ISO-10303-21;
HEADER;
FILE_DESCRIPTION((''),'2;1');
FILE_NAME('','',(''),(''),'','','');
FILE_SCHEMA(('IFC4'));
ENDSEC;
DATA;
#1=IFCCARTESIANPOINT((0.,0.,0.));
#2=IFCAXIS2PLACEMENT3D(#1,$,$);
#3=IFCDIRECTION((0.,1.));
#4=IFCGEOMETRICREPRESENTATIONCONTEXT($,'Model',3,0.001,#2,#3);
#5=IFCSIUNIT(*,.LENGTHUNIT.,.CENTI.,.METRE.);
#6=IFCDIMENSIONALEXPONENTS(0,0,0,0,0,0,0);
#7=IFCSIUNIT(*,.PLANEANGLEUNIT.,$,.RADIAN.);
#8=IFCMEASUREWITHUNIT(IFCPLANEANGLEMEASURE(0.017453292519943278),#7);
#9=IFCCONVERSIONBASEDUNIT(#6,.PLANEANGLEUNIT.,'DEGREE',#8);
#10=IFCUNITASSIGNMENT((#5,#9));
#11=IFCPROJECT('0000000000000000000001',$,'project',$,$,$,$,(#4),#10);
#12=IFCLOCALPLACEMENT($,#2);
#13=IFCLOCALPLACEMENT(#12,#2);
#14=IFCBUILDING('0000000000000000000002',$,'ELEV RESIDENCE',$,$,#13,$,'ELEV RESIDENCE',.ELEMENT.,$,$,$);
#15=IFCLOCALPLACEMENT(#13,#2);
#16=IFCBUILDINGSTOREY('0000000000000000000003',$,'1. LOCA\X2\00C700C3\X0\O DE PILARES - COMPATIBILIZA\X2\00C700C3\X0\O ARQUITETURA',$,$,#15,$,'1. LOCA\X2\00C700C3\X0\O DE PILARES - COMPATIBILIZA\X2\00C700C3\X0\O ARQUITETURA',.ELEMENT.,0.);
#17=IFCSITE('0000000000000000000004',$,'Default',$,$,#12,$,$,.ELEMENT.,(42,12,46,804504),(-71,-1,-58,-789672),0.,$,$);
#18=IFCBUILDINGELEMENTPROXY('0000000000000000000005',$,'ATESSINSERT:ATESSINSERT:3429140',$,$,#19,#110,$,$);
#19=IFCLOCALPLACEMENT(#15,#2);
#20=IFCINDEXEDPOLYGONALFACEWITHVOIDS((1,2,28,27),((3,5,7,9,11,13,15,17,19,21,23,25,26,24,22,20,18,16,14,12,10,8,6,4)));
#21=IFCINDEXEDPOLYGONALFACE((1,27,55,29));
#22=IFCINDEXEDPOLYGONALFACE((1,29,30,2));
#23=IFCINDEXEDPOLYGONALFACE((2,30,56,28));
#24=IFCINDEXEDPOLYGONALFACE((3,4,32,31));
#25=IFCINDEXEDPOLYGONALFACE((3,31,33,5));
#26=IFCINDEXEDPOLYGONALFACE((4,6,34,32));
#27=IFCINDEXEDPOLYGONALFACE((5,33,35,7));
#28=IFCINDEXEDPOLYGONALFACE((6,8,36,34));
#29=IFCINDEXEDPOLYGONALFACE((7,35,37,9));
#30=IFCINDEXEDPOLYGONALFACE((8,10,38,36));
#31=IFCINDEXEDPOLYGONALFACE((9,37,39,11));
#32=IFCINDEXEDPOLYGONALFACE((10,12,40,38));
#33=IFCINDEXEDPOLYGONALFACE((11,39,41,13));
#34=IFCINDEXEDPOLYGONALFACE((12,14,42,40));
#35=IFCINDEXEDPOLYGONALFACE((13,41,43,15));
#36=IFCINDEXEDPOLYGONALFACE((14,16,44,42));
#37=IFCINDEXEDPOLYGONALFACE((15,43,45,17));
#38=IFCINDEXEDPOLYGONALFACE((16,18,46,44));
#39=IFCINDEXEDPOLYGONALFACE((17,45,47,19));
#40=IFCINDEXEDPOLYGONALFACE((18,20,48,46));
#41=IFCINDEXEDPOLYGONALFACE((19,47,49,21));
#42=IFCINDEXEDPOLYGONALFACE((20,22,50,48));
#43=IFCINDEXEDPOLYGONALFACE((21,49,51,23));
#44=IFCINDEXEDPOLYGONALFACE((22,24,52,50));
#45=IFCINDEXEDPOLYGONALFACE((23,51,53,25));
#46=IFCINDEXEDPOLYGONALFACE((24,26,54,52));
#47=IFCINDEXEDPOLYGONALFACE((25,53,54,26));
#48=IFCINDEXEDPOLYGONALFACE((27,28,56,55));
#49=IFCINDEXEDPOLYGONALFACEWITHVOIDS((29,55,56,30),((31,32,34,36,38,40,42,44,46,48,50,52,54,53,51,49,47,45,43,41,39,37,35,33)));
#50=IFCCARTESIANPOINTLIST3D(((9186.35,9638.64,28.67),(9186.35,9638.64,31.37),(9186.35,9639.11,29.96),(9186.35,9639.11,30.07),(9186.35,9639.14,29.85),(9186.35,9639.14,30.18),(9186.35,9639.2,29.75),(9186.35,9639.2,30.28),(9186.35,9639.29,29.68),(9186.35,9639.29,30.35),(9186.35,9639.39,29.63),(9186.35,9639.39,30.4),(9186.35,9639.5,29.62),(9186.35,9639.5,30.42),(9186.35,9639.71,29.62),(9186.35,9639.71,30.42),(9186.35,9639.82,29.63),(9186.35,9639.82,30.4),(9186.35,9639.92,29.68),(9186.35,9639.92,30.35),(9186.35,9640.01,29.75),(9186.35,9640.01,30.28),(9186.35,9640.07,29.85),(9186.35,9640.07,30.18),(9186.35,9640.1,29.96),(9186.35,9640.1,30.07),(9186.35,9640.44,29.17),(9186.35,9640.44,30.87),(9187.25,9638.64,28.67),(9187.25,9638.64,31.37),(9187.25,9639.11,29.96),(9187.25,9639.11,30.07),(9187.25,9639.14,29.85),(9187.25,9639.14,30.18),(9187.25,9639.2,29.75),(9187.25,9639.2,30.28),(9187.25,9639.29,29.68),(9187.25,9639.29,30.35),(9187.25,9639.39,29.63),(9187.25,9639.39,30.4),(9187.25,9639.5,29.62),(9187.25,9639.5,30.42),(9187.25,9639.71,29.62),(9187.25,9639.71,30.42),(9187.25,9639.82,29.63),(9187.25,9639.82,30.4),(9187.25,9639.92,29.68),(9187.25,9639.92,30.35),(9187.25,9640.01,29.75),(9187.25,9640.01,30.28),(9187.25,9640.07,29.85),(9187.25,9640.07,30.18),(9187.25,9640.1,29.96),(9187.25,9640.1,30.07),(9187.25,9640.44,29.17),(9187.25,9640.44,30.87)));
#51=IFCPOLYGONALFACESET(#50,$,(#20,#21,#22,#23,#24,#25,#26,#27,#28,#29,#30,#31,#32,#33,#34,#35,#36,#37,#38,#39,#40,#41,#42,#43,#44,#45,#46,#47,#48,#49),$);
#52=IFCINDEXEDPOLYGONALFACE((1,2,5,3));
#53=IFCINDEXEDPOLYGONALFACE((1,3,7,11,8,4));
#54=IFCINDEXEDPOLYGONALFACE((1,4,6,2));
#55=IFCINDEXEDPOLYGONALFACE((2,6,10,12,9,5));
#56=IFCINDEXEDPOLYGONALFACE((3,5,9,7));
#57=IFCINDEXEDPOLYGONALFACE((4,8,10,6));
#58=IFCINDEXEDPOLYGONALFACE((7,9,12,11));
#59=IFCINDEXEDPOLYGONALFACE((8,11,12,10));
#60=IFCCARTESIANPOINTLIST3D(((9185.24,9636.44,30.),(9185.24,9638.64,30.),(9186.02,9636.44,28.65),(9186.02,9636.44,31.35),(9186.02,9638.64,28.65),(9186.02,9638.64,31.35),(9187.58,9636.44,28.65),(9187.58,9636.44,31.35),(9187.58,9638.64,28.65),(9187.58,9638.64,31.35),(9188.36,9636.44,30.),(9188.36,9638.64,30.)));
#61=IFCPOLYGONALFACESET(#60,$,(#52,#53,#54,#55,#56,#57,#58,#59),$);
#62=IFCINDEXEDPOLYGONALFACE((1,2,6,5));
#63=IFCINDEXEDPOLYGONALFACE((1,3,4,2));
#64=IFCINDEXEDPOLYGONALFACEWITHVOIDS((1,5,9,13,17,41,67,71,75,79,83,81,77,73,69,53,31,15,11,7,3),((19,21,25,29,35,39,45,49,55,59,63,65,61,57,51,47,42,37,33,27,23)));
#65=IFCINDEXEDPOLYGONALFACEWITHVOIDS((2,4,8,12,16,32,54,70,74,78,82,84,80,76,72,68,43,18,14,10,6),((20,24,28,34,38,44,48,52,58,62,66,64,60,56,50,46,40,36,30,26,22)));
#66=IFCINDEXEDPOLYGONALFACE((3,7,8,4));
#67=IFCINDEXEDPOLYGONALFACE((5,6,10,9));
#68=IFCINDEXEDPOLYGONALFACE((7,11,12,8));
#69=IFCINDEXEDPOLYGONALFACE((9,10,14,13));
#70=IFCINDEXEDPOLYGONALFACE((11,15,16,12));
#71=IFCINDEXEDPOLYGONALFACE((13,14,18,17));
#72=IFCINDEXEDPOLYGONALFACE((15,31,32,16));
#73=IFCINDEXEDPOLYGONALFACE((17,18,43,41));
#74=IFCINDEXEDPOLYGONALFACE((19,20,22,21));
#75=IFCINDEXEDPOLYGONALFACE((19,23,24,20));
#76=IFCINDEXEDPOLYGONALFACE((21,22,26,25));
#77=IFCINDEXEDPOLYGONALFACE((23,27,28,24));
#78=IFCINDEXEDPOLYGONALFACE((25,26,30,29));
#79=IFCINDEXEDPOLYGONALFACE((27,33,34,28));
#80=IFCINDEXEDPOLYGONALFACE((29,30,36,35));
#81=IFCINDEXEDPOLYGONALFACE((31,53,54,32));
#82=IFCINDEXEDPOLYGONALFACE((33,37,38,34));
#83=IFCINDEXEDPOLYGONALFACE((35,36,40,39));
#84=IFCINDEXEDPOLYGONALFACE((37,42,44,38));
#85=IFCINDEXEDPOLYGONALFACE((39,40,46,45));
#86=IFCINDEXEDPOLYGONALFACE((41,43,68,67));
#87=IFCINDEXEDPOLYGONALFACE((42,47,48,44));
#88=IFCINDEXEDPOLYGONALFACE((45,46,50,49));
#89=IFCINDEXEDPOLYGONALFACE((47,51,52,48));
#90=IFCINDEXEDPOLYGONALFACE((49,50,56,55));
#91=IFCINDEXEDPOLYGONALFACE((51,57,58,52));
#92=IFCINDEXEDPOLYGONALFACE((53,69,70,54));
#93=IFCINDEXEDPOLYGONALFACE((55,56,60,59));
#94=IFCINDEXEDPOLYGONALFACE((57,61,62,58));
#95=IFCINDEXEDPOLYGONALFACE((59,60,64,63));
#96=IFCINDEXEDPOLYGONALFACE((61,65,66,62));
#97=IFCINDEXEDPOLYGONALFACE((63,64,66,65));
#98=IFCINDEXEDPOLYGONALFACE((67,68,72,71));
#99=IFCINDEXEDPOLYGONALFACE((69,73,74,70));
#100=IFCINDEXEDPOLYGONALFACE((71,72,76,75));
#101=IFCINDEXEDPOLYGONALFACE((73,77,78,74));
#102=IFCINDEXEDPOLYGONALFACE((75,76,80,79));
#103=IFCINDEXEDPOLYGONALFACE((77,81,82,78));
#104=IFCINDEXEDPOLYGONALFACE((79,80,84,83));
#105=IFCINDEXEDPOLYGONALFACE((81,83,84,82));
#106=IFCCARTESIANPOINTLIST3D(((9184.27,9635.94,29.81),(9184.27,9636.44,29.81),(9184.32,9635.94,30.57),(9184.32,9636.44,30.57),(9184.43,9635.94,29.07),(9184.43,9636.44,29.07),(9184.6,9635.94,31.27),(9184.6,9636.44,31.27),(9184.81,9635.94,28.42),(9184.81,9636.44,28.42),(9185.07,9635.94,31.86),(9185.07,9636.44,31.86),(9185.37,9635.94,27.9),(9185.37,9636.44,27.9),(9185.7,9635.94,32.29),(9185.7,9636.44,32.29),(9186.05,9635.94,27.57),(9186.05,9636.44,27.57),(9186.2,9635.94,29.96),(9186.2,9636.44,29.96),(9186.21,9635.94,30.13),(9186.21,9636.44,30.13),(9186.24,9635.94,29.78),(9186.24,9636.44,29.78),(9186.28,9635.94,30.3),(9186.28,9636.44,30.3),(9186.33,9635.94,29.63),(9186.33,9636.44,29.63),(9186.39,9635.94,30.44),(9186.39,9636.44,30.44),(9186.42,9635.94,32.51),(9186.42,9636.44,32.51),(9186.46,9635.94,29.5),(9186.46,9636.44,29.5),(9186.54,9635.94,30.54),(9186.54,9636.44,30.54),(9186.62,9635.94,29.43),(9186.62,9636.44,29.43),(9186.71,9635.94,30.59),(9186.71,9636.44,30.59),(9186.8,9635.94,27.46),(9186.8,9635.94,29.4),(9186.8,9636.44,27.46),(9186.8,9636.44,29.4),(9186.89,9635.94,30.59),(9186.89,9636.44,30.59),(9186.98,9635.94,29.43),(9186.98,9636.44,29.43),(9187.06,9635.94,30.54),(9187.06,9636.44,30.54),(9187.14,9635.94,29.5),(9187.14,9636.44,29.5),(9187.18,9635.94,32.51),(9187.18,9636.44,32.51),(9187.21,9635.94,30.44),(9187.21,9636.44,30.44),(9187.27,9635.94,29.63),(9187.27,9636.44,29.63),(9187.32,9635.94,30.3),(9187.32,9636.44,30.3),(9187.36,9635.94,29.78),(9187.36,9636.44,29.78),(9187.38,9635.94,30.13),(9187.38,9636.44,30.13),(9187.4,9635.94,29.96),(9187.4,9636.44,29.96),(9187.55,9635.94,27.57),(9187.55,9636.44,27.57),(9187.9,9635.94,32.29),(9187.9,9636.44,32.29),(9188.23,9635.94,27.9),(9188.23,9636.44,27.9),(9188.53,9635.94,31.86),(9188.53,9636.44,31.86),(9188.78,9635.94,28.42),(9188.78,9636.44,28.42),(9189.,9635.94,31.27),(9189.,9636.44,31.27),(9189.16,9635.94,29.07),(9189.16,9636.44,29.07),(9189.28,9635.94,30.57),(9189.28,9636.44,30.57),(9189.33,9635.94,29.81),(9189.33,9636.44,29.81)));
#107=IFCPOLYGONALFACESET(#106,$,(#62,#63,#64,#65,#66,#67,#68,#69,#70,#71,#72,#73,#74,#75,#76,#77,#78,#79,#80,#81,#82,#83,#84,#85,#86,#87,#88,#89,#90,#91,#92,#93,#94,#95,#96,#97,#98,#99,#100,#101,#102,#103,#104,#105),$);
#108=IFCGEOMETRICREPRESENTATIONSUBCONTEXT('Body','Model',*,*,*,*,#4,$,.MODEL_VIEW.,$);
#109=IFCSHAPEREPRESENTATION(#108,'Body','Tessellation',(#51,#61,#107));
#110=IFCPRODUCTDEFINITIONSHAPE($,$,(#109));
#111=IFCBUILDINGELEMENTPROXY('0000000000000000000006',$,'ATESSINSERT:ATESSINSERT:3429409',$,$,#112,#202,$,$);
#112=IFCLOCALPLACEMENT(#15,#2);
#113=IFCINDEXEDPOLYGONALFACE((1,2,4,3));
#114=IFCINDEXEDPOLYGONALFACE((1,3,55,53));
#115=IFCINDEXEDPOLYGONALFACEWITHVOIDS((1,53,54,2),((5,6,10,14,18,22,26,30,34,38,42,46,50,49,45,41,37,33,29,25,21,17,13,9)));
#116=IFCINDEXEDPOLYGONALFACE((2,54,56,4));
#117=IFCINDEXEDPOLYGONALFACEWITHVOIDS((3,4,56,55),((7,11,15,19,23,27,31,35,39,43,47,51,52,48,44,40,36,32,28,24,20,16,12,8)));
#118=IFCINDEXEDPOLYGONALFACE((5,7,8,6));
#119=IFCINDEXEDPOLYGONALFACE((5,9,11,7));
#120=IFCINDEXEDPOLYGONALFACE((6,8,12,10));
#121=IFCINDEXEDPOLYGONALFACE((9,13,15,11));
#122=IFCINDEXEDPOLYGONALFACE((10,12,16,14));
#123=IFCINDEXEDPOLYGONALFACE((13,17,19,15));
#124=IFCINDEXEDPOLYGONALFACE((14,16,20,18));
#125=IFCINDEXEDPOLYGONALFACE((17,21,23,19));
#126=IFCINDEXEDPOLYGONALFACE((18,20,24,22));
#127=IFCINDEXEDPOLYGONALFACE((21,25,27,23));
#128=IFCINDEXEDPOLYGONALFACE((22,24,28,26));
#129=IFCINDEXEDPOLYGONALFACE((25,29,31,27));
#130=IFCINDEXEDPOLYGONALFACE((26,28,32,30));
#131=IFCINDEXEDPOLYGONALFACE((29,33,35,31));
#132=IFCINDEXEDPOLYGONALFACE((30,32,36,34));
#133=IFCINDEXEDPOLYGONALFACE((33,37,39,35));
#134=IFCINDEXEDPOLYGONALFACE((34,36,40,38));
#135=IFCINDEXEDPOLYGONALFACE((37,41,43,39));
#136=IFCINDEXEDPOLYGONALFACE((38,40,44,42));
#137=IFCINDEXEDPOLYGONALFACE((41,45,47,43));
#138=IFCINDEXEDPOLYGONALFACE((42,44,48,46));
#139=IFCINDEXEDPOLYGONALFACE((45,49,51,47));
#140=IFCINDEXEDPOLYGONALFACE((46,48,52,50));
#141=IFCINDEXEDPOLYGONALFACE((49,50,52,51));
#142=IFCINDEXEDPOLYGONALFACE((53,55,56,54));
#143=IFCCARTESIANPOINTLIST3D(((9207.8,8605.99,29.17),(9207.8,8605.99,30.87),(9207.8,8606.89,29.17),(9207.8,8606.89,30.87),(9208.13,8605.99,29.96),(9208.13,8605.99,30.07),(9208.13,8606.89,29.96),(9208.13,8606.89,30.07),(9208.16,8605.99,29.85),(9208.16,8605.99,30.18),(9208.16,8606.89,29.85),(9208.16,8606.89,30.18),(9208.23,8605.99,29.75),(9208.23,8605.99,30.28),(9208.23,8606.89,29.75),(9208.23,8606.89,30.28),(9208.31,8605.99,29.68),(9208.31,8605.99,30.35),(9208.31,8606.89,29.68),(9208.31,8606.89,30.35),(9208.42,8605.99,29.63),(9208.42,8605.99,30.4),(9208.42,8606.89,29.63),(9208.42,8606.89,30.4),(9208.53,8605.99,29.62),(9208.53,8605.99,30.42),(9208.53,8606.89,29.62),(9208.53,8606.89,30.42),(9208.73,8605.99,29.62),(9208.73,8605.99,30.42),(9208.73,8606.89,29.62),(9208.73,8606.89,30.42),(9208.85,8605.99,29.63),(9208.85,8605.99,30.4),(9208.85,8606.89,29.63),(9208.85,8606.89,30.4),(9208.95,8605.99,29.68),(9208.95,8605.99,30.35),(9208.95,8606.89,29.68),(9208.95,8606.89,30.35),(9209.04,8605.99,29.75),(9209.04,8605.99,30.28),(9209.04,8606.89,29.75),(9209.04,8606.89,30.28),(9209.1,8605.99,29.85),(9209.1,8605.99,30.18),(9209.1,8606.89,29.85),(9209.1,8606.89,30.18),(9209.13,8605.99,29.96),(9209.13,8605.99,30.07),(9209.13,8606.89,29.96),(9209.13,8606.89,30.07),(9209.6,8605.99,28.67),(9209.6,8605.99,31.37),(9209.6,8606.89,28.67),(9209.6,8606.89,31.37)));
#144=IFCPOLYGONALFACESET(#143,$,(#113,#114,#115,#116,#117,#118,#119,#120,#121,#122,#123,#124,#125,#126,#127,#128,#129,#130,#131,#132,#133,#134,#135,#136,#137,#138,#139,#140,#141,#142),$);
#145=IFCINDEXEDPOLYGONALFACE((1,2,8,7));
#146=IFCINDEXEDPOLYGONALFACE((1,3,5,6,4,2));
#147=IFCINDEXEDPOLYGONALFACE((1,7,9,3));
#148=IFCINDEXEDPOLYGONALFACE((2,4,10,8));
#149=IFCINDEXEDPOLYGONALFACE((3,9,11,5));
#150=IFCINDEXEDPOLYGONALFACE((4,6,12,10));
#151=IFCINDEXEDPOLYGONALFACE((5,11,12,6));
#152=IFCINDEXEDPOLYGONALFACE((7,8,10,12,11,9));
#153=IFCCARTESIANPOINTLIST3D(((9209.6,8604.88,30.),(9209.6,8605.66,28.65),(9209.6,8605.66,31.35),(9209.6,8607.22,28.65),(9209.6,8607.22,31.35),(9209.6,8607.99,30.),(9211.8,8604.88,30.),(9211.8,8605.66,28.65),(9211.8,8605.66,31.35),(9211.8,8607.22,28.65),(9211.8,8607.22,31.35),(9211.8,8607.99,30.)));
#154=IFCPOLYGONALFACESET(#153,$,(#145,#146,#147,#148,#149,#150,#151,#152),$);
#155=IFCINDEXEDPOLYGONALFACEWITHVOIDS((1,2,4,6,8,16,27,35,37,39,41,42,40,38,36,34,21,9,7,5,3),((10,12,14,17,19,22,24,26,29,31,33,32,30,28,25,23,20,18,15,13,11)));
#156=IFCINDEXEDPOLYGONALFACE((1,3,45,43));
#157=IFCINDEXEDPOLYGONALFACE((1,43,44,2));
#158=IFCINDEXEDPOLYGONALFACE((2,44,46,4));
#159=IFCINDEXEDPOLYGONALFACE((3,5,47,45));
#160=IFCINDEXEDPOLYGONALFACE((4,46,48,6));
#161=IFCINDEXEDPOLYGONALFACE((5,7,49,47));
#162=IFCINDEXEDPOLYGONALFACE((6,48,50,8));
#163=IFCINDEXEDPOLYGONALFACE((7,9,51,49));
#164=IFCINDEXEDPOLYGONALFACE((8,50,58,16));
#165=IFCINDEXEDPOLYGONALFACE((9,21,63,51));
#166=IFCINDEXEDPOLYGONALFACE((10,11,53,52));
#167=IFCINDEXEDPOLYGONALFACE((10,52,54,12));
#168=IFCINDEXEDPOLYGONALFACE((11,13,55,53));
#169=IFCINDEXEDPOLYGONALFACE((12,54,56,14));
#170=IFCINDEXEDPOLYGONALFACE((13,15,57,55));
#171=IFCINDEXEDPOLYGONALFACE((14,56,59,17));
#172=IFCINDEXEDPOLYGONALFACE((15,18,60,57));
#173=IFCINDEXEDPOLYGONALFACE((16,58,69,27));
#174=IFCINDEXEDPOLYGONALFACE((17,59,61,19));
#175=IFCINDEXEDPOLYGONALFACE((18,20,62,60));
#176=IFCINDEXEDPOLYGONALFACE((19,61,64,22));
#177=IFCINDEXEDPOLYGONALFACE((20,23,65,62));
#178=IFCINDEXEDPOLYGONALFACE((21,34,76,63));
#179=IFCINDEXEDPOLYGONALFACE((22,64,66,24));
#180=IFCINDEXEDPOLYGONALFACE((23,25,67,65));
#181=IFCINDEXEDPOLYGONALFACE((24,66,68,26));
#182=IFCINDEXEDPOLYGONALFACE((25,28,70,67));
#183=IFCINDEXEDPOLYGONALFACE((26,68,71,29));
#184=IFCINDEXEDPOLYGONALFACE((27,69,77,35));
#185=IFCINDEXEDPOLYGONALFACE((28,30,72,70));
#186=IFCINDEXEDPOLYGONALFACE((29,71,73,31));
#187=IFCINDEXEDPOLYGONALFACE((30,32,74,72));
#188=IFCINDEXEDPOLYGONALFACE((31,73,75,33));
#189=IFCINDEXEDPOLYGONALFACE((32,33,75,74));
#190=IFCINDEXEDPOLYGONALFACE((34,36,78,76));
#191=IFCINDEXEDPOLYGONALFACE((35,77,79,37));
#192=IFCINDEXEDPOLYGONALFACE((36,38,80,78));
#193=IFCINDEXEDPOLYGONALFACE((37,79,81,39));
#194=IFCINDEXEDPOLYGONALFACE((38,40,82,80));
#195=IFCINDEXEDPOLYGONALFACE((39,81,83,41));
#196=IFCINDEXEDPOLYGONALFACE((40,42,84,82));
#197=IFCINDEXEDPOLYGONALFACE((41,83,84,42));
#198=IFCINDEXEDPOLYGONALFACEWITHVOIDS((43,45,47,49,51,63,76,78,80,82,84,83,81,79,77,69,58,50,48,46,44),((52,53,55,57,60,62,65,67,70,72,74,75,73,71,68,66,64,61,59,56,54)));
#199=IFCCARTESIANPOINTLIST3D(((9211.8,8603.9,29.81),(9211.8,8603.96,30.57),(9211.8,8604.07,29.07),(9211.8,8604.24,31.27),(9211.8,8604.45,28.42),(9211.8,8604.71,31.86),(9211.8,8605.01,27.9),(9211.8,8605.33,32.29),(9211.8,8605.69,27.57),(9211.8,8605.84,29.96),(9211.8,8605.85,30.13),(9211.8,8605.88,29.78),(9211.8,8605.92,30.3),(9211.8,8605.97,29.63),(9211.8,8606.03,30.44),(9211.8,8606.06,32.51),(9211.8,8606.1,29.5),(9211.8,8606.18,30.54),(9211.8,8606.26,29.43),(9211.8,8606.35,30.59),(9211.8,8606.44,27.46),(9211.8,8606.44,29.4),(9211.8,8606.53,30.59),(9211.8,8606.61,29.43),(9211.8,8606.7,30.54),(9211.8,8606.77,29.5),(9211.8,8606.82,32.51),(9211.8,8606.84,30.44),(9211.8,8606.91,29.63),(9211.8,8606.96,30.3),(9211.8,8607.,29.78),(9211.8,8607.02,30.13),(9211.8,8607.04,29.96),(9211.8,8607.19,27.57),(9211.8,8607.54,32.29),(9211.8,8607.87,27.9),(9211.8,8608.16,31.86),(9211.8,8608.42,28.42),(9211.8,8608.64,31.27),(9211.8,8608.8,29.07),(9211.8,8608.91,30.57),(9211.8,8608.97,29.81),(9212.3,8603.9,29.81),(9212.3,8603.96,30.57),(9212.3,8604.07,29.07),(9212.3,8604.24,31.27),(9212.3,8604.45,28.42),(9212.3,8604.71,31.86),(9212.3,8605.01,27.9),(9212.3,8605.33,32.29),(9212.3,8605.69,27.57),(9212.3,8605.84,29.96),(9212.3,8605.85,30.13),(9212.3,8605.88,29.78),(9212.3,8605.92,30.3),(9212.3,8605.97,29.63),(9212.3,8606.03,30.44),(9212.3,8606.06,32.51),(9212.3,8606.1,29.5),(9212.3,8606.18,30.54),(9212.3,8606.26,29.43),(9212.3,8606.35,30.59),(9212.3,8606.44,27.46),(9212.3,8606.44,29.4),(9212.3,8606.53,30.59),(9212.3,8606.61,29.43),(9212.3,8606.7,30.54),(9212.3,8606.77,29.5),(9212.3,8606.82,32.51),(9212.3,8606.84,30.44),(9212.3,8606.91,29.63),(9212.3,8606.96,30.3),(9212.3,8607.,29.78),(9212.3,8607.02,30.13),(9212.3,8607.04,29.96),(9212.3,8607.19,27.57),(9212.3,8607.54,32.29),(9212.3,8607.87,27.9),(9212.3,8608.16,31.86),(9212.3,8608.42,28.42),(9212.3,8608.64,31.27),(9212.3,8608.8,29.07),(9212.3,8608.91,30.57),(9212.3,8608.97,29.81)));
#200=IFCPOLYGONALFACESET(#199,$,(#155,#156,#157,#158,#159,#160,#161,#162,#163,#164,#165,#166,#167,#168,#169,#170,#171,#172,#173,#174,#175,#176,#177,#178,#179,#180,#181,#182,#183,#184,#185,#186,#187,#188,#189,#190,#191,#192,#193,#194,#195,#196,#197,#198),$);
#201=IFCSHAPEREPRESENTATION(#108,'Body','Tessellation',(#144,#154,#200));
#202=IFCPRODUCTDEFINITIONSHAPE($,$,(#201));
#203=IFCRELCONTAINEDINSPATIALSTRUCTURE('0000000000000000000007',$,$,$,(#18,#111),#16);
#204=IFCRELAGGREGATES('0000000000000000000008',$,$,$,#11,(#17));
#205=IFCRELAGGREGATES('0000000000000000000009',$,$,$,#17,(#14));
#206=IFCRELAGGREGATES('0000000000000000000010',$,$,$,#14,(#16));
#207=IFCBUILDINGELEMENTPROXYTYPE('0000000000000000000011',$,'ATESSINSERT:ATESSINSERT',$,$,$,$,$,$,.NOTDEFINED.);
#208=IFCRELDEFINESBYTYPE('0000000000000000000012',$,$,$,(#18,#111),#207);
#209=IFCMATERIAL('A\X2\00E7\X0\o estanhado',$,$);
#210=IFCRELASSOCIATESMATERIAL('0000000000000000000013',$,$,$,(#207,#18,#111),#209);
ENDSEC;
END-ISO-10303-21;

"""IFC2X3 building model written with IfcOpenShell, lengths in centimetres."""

from ifc_helpers import new_model, entity, si_unit, converted_unit, direction, frame, frame_2d, origin, place, context, subcontext, project, spatial, polyline, circle_curve, parameter, trimmed, segment, composite_curve, hollow_circle, outline, extrude, source, transform, mapped, material, type_object, type_shapes, element, save


model = new_model("IFC2X3")

# Units and contexts
model_context = context("Model", 3, precision=0.001, world=origin(), true_north=direction((0.0, 1.0)))
body_context = subcontext(model_context, "Body", "Model", "MODEL_VIEW")
ifc_project = project(units=[si_unit("LENGTHUNIT", "METRE", prefix="CENTI"), converted_unit("PLANEANGLEUNIT", "DEGREE", entity("IfcPlaneAngleMeasure", 0.017453292519943278), si_unit("PLANEANGLEUNIT", "RADIAN"), dimensions=[0, 0, 0, 0, 0, 0, 0])], contexts=[model_context])

# Site, building, storey
site_placement = place(None, origin())
site = spatial("IfcSite", under=ifc_project, at=site_placement, Name="Default", CompositionType="ELEMENT", RefLatitude=(42, 12, 46, 804504), RefLongitude=(-71, -1, -58, -789672), RefElevation=0.0)
building_placement = place(site_placement, origin())
building = spatial("IfcBuilding", under=site, at=building_placement, Name="ELEV RESIDENCE", LongName="ELEV RESIDENCE", CompositionType="ELEMENT")
storey_placement = place(building_placement, origin())
storey = spatial("IfcBuildingStorey", under=building, at=storey_placement, Name="1. LOCAÇÃO DE PILARES - COMPATIBILIZAÇÃO ARQUITETURA", LongName="1. LOCAÇÃO DE PILARES - COMPATIBILIZAÇÃO ARQUITETURA", CompositionType="ELEMENT", Elevation=0.0)

# Building element proxies
ifc_material_1 = material(Name="Aço estanhado")
building_element_proxy_type_1 = type_object("IfcBuildingElementProxyType", Name="ATESSINSERT:ATESSINSERT", PredefinedType="NOTDEFINED", material=ifc_material_1)
shared_shape_1 = source(origin(), body_context, "Body", "SweptSolid", [
    extrude(outline(polyline([(-1.35, -0.9), (1.35, -0.9), (0.85, 0.9), (-0.85, 0.9), (-1.35, -0.9)]), holes=[composite_curve([segment(trimmed(circle_curve(frame_2d((0.0, 0.17), x_axis=(1.0, 0.0)), 0.4), [parameter(0.0)], [parameter(180.0)], True, "PARAMETER"), False, "CONTINUOUS"), segment(polyline([(0.4, 0.17), (0.4, -0.03)]), True, "CONTINUOUS"), segment(trimmed(circle_curve(frame_2d((0.0, -0.03), x_axis=(1.0, 0.0)), 0.4), [parameter(180.0)], [parameter(0.0)], True, "PARAMETER"), False, "CONTINUOUS"), segment(polyline([(-0.4, -0.03), (-0.4, 0.17)]), True, "CONTINUOUS")], self_intersect=False)]), frame((-1.4, -0.45, 30.02), z_axis=(0.0, 1.0, 0.0), x_axis=(0.0, 0.0, 1.0)), (0.0, 0.0, 1.0), 0.9),
    extrude(outline(polyline([(-0.78, -1.35), (0.78, -1.35), (1.56, 0.0), (0.78, 1.35), (-0.78, 1.35), (-1.56, 0.0), (-0.78, -1.35)])), frame((-4.5, 0.0, 30.0), z_axis=(1.0, 0.0, 0.0), x_axis=(0.0, 0.5, 0.866025)), (0.0, 0.0, 1.0), 2.2),
    extrude(hollow_circle(Radius=2.54, WallThickness=1.94, at=frame_2d((0.0, 0.0), x_axis=(1.0, 0.0))), frame((-5.0, 0.0, 30.0), z_axis=(1.0, 0.0, 0.0), x_axis=(0.0, 0.0, -1.0)), (0.0, 0.0, 1.0), 0.5),
])
type_shapes(building_element_proxy_type_1, [shared_shape_1])
for number, where, z_axis, x_axis, name in (
    (1, (9186.8, 9640.94, 0.0), (0.0, 0.0, 1.0), (0.0, 1.0, 0.0), "ATESSINSERT:ATESSINSERT:3429140"),
    (2, (9207.3, 8606.44, 0.0), (0.0, 0.0, 1.0), (-1.0, 0.0, 0.0), "ATESSINSERT:ATESSINSERT:3429409"),
):
    element("IfcBuildingElementProxy", number, at=place(storey_placement, frame(where, z_axis=z_axis, x_axis=x_axis)), inside=storey, type_object=building_element_proxy_type_1, material=ifc_material_1, Name=name, context=body_context, shape_type="MappedRepresentation", body=[
        mapped(shared_shape_1, transform((0.0, 0.0, 0.0), scale=1.0)),
    ])

save(model, "model.ifc")
